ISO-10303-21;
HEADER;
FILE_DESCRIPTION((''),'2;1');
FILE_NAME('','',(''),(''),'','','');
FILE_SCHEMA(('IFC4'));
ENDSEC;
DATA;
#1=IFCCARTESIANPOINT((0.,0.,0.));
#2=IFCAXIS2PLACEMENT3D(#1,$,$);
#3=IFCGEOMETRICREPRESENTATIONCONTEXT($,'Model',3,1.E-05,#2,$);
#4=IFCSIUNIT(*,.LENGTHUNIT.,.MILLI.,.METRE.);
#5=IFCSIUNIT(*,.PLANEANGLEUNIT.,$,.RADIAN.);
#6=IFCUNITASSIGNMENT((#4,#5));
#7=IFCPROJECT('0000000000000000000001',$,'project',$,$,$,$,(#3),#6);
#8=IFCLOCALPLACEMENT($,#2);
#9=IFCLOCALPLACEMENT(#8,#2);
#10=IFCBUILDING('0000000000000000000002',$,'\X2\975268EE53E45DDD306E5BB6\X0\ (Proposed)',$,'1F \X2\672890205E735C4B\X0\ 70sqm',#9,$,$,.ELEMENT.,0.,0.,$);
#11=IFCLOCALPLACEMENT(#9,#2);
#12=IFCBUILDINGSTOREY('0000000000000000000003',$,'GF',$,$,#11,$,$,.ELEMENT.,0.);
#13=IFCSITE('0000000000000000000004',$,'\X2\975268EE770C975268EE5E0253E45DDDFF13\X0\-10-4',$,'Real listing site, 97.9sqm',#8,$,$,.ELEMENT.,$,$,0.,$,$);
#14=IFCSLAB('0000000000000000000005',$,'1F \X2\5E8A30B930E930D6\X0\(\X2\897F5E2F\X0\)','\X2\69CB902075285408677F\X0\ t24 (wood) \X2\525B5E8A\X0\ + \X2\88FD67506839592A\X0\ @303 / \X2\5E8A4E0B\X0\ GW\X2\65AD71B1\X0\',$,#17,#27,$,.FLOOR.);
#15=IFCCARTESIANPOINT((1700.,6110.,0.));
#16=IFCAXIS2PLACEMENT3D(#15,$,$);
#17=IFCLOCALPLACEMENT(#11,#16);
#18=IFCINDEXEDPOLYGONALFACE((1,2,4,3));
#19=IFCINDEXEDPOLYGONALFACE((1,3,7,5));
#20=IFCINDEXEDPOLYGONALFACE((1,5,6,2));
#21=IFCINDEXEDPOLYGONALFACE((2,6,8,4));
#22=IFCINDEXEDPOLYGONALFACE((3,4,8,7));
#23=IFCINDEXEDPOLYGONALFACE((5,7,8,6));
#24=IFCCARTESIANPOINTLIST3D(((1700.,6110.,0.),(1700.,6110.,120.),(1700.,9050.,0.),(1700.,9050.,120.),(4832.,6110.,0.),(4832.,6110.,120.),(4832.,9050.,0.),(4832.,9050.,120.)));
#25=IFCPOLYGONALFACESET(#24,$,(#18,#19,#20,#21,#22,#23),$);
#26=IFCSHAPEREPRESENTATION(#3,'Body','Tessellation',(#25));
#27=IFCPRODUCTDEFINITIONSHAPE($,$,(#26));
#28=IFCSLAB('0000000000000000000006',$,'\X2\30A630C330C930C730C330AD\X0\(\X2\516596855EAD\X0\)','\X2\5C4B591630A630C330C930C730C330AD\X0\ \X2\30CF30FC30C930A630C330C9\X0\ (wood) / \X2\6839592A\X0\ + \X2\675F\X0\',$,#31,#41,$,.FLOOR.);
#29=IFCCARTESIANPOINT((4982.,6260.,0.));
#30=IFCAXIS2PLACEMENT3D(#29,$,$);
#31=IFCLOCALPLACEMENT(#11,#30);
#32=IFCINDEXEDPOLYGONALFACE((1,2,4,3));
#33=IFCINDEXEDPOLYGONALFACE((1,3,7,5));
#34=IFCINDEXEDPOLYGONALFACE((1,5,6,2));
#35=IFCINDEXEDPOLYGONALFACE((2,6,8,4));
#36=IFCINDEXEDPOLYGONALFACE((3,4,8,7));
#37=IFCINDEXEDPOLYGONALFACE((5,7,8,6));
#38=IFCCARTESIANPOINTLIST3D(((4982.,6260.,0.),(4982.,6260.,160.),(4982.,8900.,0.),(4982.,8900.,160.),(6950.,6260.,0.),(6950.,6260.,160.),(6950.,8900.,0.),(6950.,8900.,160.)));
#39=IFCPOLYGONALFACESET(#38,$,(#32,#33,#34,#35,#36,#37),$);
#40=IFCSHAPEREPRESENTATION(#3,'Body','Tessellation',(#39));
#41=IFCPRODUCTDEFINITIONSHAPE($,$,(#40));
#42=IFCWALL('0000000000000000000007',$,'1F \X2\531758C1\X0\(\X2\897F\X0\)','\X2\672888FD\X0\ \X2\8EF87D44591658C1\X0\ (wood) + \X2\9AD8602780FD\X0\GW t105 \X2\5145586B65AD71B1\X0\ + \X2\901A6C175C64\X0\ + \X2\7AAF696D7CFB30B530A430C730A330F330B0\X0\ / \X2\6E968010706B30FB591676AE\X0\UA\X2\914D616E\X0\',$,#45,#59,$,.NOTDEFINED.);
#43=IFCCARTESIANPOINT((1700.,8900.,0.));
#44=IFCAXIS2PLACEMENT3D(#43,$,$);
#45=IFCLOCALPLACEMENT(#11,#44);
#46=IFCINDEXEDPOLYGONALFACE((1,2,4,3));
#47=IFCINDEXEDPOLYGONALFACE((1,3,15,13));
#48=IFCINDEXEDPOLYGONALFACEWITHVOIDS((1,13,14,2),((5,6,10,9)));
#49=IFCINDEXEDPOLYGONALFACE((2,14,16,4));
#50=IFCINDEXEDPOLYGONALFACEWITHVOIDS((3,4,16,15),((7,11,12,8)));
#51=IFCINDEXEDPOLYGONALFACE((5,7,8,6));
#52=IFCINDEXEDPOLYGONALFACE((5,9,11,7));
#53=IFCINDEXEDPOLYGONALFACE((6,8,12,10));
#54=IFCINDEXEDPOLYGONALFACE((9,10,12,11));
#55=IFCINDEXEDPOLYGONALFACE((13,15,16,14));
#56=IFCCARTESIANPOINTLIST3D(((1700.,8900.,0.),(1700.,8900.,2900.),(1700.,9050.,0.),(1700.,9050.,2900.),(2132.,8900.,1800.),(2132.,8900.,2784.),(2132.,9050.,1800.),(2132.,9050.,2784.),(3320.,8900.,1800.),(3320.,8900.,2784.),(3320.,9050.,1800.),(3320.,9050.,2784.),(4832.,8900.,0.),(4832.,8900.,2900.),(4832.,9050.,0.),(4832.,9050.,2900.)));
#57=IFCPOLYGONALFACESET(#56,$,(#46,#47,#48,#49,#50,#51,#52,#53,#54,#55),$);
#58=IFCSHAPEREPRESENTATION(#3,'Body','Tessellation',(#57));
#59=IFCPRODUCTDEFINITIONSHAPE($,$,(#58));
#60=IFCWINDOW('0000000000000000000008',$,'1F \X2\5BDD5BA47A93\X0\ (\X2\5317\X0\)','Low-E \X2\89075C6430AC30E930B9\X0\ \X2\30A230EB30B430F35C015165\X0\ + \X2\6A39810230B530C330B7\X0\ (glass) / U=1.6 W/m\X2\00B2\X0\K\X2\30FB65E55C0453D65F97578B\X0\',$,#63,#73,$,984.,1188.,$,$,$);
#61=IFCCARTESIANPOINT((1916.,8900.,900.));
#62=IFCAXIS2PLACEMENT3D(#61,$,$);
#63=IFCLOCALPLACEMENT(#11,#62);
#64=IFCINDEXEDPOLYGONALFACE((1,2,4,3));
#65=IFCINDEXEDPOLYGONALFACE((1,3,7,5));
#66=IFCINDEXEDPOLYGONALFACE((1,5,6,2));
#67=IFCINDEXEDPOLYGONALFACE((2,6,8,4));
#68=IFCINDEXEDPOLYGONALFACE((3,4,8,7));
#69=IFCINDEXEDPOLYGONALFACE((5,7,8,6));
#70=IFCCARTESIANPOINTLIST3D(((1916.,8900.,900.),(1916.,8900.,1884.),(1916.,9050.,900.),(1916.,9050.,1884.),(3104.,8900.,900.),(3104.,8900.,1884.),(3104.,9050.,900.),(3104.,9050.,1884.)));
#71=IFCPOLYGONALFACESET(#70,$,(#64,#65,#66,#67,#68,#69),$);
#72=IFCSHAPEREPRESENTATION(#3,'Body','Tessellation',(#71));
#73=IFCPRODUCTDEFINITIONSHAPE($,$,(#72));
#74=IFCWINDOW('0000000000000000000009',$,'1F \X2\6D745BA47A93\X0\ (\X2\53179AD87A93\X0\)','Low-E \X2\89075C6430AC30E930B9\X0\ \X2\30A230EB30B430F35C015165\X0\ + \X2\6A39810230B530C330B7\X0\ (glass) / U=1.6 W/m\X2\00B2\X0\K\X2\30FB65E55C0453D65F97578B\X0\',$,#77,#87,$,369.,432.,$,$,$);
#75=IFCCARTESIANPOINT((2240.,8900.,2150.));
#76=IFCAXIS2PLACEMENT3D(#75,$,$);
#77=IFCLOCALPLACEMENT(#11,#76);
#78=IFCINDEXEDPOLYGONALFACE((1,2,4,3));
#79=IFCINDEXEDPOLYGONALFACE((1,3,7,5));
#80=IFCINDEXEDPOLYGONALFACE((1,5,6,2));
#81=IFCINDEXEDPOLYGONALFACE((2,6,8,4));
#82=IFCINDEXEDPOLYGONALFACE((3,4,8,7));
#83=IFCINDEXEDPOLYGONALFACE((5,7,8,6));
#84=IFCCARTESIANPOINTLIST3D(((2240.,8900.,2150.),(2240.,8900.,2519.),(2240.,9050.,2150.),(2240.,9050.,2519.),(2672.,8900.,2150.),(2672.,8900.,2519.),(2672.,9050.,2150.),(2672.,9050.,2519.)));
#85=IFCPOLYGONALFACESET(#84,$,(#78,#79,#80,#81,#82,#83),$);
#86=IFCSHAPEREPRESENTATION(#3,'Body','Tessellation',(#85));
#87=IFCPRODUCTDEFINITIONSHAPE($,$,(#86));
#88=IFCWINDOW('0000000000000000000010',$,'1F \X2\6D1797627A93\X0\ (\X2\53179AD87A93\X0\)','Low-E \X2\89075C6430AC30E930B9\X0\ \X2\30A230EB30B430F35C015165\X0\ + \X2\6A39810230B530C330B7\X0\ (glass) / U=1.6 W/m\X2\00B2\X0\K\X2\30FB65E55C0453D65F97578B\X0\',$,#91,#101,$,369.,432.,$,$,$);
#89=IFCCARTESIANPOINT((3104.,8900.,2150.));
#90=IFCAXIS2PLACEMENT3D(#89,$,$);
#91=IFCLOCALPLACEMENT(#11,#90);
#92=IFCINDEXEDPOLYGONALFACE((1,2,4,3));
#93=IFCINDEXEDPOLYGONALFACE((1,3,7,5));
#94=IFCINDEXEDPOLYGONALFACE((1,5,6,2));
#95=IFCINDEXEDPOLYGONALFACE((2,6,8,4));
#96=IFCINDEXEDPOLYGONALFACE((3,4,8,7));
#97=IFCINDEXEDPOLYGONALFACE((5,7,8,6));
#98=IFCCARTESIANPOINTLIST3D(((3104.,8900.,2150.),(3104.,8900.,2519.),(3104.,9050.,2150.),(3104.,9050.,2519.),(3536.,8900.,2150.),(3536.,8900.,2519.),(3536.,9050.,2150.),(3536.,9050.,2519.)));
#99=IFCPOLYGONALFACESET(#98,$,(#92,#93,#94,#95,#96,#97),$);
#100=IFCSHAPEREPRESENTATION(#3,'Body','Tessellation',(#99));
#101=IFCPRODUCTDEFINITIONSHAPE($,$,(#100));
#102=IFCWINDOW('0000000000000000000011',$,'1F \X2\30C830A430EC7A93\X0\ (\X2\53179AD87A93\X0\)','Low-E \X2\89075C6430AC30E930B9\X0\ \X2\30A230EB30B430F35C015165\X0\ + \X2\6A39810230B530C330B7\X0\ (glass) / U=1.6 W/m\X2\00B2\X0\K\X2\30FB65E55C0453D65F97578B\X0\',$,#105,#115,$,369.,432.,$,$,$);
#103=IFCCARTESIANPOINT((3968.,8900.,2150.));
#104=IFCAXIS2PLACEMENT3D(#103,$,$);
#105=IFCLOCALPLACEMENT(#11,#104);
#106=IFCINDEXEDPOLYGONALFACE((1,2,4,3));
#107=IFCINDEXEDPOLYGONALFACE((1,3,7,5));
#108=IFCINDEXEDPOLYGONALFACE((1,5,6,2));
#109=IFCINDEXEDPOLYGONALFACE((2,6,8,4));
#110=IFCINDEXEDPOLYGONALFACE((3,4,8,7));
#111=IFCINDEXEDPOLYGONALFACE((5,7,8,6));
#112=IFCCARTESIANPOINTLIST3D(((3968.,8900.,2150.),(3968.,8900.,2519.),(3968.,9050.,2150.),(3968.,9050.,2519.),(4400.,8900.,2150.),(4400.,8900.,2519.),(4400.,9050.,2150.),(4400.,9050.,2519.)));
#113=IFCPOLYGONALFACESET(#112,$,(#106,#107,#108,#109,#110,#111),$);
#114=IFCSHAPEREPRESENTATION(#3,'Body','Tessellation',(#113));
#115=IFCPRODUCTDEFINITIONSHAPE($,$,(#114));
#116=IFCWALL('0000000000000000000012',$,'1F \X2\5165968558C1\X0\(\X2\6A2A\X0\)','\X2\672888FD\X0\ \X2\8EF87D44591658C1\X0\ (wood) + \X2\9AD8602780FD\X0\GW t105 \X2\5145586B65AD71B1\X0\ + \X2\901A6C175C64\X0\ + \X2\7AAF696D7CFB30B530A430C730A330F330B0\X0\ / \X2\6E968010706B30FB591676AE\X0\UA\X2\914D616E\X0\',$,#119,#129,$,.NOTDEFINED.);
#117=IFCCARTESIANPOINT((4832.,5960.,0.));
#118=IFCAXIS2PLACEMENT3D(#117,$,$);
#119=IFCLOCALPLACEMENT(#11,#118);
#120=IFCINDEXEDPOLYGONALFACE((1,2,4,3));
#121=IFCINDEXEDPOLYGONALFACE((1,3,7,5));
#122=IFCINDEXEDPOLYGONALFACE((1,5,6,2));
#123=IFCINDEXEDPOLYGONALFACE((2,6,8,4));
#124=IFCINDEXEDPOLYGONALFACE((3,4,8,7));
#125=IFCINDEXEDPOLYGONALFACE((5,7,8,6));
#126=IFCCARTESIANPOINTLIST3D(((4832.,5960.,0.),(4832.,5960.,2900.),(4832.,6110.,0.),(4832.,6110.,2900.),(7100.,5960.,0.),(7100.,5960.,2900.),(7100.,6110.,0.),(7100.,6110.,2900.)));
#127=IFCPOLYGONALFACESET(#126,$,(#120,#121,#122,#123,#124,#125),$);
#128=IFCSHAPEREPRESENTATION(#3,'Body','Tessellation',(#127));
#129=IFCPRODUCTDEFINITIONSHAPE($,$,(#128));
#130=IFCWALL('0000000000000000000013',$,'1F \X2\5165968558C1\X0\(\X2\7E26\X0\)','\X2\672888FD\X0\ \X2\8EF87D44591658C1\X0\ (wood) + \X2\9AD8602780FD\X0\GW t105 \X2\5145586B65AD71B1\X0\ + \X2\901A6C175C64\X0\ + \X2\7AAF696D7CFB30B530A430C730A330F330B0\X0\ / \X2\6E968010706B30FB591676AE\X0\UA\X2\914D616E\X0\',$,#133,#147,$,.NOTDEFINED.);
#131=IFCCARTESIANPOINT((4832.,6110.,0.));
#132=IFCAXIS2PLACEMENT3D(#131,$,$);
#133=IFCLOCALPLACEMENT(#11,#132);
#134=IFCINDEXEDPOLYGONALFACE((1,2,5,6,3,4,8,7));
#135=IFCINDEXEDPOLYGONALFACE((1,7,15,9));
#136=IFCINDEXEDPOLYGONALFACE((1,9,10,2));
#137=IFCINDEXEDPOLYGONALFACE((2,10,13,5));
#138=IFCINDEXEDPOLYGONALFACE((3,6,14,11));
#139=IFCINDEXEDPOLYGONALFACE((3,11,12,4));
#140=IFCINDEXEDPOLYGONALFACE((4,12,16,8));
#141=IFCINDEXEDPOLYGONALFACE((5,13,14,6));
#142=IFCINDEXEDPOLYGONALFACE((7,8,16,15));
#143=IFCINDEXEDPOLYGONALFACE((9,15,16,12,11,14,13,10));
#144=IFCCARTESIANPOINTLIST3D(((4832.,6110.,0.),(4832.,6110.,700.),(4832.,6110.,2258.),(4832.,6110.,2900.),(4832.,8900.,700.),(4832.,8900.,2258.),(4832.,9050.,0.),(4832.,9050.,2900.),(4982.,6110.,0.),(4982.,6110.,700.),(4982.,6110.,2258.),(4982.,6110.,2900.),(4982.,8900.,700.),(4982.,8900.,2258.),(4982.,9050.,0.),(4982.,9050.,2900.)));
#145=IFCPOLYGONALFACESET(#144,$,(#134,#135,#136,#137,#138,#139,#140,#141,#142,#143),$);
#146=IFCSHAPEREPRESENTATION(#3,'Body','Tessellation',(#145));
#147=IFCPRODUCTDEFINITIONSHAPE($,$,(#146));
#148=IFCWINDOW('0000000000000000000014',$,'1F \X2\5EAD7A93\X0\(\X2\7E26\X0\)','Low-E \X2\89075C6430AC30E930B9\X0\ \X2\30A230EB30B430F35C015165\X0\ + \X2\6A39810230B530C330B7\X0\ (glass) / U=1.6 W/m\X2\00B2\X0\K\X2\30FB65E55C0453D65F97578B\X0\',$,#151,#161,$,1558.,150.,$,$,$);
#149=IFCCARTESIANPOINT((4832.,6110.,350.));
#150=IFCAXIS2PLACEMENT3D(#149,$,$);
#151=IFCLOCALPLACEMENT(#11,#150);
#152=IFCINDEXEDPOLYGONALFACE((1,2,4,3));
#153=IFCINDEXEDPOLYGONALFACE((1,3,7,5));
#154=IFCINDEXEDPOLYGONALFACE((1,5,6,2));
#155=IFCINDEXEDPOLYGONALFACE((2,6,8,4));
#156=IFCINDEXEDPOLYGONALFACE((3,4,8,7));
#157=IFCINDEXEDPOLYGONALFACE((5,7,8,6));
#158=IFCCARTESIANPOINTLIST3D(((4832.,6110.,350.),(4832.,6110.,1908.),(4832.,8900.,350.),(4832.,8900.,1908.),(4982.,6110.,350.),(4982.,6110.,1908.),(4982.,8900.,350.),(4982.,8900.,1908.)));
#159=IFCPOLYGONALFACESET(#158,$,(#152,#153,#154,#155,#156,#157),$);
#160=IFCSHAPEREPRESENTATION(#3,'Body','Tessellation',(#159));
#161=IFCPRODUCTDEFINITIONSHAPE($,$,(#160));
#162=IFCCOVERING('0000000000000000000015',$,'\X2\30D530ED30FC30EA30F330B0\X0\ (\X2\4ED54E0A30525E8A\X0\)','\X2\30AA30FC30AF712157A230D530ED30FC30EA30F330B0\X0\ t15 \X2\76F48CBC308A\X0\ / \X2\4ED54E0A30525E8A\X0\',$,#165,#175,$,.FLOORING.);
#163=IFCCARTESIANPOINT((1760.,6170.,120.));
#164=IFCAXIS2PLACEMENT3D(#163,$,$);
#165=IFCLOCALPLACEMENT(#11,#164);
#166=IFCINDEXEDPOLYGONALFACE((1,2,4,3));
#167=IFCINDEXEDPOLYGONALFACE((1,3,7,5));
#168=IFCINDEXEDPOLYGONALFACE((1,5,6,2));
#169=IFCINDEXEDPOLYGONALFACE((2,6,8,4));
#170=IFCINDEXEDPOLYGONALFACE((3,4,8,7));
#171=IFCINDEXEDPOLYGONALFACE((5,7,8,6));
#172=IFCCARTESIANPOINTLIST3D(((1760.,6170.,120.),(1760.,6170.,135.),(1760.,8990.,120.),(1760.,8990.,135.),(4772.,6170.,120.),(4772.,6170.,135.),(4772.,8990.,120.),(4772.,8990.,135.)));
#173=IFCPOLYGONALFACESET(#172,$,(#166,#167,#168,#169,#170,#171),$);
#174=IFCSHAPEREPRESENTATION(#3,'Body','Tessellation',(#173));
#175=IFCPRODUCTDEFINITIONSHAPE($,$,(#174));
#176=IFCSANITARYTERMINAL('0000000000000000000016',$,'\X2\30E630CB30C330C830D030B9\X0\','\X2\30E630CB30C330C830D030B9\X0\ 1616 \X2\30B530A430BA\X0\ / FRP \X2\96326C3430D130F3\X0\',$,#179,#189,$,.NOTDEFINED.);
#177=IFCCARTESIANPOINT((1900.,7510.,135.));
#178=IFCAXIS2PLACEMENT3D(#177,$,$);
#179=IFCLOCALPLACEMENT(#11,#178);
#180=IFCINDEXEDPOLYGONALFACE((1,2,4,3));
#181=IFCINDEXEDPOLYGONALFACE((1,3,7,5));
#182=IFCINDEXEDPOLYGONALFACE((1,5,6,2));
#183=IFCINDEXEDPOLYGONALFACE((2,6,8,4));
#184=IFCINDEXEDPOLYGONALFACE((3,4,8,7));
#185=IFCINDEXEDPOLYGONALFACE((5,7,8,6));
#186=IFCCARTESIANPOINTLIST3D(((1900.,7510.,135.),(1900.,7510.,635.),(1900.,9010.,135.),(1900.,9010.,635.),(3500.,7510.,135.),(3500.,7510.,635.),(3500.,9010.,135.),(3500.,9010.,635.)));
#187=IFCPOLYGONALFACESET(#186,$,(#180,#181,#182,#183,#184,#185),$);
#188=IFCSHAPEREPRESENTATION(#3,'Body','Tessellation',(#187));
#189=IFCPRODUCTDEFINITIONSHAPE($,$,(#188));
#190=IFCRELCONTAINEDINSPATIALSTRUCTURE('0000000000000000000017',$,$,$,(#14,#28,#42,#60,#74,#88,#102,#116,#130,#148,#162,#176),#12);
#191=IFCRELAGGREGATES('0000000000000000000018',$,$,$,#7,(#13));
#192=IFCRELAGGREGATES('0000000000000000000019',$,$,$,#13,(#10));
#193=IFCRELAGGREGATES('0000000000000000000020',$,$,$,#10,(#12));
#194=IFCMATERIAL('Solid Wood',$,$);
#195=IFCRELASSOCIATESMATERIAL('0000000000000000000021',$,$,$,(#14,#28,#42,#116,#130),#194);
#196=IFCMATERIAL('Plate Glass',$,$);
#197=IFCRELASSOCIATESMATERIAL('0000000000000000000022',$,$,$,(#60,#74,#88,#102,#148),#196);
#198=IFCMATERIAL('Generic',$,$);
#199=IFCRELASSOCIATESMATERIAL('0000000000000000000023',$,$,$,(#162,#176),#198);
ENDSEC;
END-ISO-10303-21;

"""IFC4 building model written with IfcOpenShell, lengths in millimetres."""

from ifc_helpers import new_model, si_unit, frame, frame_2d, origin, place, context, project, spatial, rectangle, extrude, material, element, fill, save


model = new_model("IFC4")

# Units and contexts
model_context = context("Model", 3, precision=1e-05, world=origin())
ifc_project = project(units=[si_unit("LENGTHUNIT", "METRE", prefix="MILLI"), si_unit("PLANEANGLEUNIT", "RADIAN")], contexts=[model_context])

# Site, building, storey
site_placement = place(None, origin())
site = spatial("IfcSite", under=ifc_project, at=site_placement, Name="青森県青森市古川３-10-4", ObjectType="Real listing site, 97.9sqm", CompositionType="ELEMENT", RefElevation=0.0)
building_placement = place(site_placement, origin())
building = spatial("IfcBuilding", under=site, at=building_placement, Name="青森古川の家 (Proposed)", ObjectType="1F 木造平屋 70sqm", CompositionType="ELEMENT", ElevationOfRefHeight=0.0, ElevationOfTerrain=0.0)
storey_placement = place(building_placement, origin())
storey = spatial("IfcBuildingStorey", under=building, at=storey_placement, Name="GF", CompositionType="ELEMENT", Elevation=0.0)

# Slabs
ifc_material_1 = material(Name="Solid Wood")
slab_1_placement = place(storey_placement, frame((1700.0, 6110.0, 0.0)))
element("IfcSlab", 1, at=slab_1_placement, inside=storey, material=ifc_material_1, Name="1F 床スラブ(西帯)", Description="構造用合板 t24 (wood) 剛床 + 製材根太 @303 / 床下 GW断熱", PredefinedType="FLOOR", context=model_context, shape_type="SweptSolid", body=[
    extrude(rectangle(XDim=3132.0, YDim=2940.0, at=frame_2d((1566.0, 1470.0))), frame((1700.0, 6110.0, 0.0)), (0.0, 0.0, 1.0), 120.0),
])
slab_2_placement = place(storey_placement, frame((4982.0, 6260.0, 0.0)))
element("IfcSlab", 2, at=slab_2_placement, inside=storey, material=ifc_material_1, Name="ウッドデッキ(入隅庭)", Description="屋外ウッドデッキ ハードウッド (wood) / 根太 + 束", PredefinedType="FLOOR", context=model_context, shape_type="SweptSolid", body=[
    extrude(rectangle(XDim=1968.0, YDim=2640.0, at=frame_2d((984.0, 1320.0))), frame((4982.0, 6260.0, 0.0)), (0.0, 0.0, 1.0), 160.0),
])

# Wall, openings, windows
wall_1_placement = place(storey_placement, frame((1700.0, 8900.0, 0.0)))
wall_1 = element("IfcWall", 3, at=wall_1_placement, inside=storey, material=ifc_material_1, Name="1F 北壁(西)", Description="木製 軸組外壁 (wood) + 高性能GW t105 充填断熱 + 通気層 + 窯業系サイディング / 準耐火・外皮UA配慮", PredefinedType="NOTDEFINED", context=model_context, shape_type="SweptSolid", body=[
    extrude(rectangle(XDim=3132.0, YDim=150.0, at=frame_2d((1566.0, 75.0))), frame((1700.0, 8900.0, 0.0)), (0.0, 0.0, 1.0), 2900.0),
])
opening_1_placement = place(storey_placement, frame((1916.0, 8900.0, 900.0)))
opening_1 = element("IfcOpeningElement", 4, at=opening_1_placement, cuts=wall_1, PredefinedType="NOTDEFINED", context=model_context, shape_type="SweptSolid", body=[
    extrude(rectangle(XDim=1188.0, YDim=150.0, at=frame_2d((594.0, 75.0))), frame((1916.0, 8900.0, 900.0)), (0.0, 0.0, 1.0), 984.0),
])
opening_2_placement = place(storey_placement, frame((2240.0, 8900.0, 2150.0)))
opening_2 = element("IfcOpeningElement", 5, at=opening_2_placement, cuts=wall_1, PredefinedType="NOTDEFINED", context=model_context, shape_type="SweptSolid", body=[
    extrude(rectangle(XDim=432.0, YDim=150.0, at=frame_2d((216.0, 75.0))), frame((2240.0, 8900.0, 2150.0)), (0.0, 0.0, 1.0), 369.0),
])
opening_3_placement = place(storey_placement, frame((3104.0, 8900.0, 2150.0)))
opening_3 = element("IfcOpeningElement", 6, at=opening_3_placement, cuts=wall_1, PredefinedType="NOTDEFINED", context=model_context, shape_type="SweptSolid", body=[
    extrude(rectangle(XDim=432.0, YDim=150.0, at=frame_2d((216.0, 75.0))), frame((3104.0, 8900.0, 2150.0)), (0.0, 0.0, 1.0), 369.0),
])
opening_4_placement = place(storey_placement, frame((3968.0, 8900.0, 2150.0)))
opening_4 = element("IfcOpeningElement", 7, at=opening_4_placement, cuts=wall_1, PredefinedType="NOTDEFINED", context=model_context, shape_type="SweptSolid", body=[
    extrude(rectangle(XDim=432.0, YDim=150.0, at=frame_2d((216.0, 75.0))), frame((3968.0, 8900.0, 2150.0)), (0.0, 0.0, 1.0), 369.0),
])
ifc_material_2 = material(Name="Plate Glass")
window_1_placement = place(storey_placement, frame((1916.0, 8900.0, 900.0)))
window_1 = element("IfcWindow", 8, at=window_1_placement, inside=storey, material=ifc_material_2, Name="1F 寝室窓 (北)", Description="Low-E 複層ガラス アルゴン封入 + 樹脂サッシ (glass) / U=1.6 W/m²K・日射取得型", OverallHeight=984.0, OverallWidth=1188.0, context=model_context, shape_type="SweptSolid", body=[
    extrude(rectangle(XDim=1188.0, YDim=150.0, at=frame_2d((594.0, 75.0))), frame((1916.0, 8900.0, 900.0)), (0.0, 0.0, 1.0), 984.0),
])
fill(opening_1, window_1)
window_2_placement = place(storey_placement, frame((2240.0, 8900.0, 2150.0)))
window_2 = element("IfcWindow", 9, at=window_2_placement, inside=storey, material=ifc_material_2, Name="1F 浴室窓 (北高窓)", Description="Low-E 複層ガラス アルゴン封入 + 樹脂サッシ (glass) / U=1.6 W/m²K・日射取得型", OverallHeight=369.0, OverallWidth=432.0, context=model_context, shape_type="SweptSolid", body=[
    extrude(rectangle(XDim=432.0, YDim=150.0, at=frame_2d((216.0, 75.0))), frame((2240.0, 8900.0, 2150.0)), (0.0, 0.0, 1.0), 369.0),
])
fill(opening_2, window_2)
window_3_placement = place(storey_placement, frame((3104.0, 8900.0, 2150.0)))
window_3 = element("IfcWindow", 10, at=window_3_placement, inside=storey, material=ifc_material_2, Name="1F 洗面窓 (北高窓)", Description="Low-E 複層ガラス アルゴン封入 + 樹脂サッシ (glass) / U=1.6 W/m²K・日射取得型", OverallHeight=369.0, OverallWidth=432.0, context=model_context, shape_type="SweptSolid", body=[
    extrude(rectangle(XDim=432.0, YDim=150.0, at=frame_2d((216.0, 75.0))), frame((3104.0, 8900.0, 2150.0)), (0.0, 0.0, 1.0), 369.0),
])
fill(opening_3, window_3)
window_4_placement = place(storey_placement, frame((3968.0, 8900.0, 2150.0)))
window_4 = element("IfcWindow", 11, at=window_4_placement, inside=storey, material=ifc_material_2, Name="1F トイレ窓 (北高窓)", Description="Low-E 複層ガラス アルゴン封入 + 樹脂サッシ (glass) / U=1.6 W/m²K・日射取得型", OverallHeight=369.0, OverallWidth=432.0, context=model_context, shape_type="SweptSolid", body=[
    extrude(rectangle(XDim=432.0, YDim=150.0, at=frame_2d((216.0, 75.0))), frame((3968.0, 8900.0, 2150.0)), (0.0, 0.0, 1.0), 369.0),
])
fill(opening_4, window_4)

# Wall
wall_2_placement = place(storey_placement, frame((4832.0, 5960.0, 0.0)))
element("IfcWall", 12, at=wall_2_placement, inside=storey, material=ifc_material_1, Name="1F 入隅壁(横)", Description="木製 軸組外壁 (wood) + 高性能GW t105 充填断熱 + 通気層 + 窯業系サイディング / 準耐火・外皮UA配慮", PredefinedType="NOTDEFINED", context=model_context, shape_type="SweptSolid", body=[
    extrude(rectangle(XDim=2268.0, YDim=150.0, at=frame_2d((1134.0, 75.0))), frame((4832.0, 5960.0, 0.0)), (0.0, 0.0, 1.0), 2900.0),
])

# Wall, opening, window
wall_3_placement = place(storey_placement, frame((4832.0, 6110.0, 0.0)))
wall_3 = element("IfcWall", 13, at=wall_3_placement, inside=storey, material=ifc_material_1, Name="1F 入隅壁(縦)", Description="木製 軸組外壁 (wood) + 高性能GW t105 充填断熱 + 通気層 + 窯業系サイディング / 準耐火・外皮UA配慮", PredefinedType="NOTDEFINED", context=model_context, shape_type="SweptSolid", body=[
    extrude(rectangle(XDim=150.0, YDim=2940.0, at=frame_2d((75.0, 1470.0))), frame((4832.0, 6110.0, 0.0)), (0.0, 0.0, 1.0), 2900.0),
])
opening_5_placement = place(storey_placement, frame((4832.0, 6110.0, 350.0)))
opening_5 = element("IfcOpeningElement", 14, at=opening_5_placement, cuts=wall_3, PredefinedType="NOTDEFINED", context=model_context, shape_type="SweptSolid", body=[
    extrude(rectangle(XDim=150.0, YDim=2790.0, at=frame_2d((75.0, 1395.0))), frame((4832.0, 6110.0, 350.0)), (0.0, 0.0, 1.0), 1558.0),
])
window_5_placement = place(storey_placement, frame((4832.0, 6110.0, 350.0)))
window_5 = element("IfcWindow", 15, at=window_5_placement, inside=storey, material=ifc_material_2, Name="1F 庭窓(縦)", Description="Low-E 複層ガラス アルゴン封入 + 樹脂サッシ (glass) / U=1.6 W/m²K・日射取得型", OverallHeight=1558.0, OverallWidth=150.0, context=model_context, shape_type="SweptSolid", body=[
    extrude(rectangle(XDim=150.0, YDim=2790.0, at=frame_2d((75.0, 1395.0))), frame((4832.0, 6110.0, 350.0)), (0.0, 0.0, 1.0), 1558.0),
])
fill(opening_5, window_5)

# Covering
ifc_material_3 = material(Name="Generic")
covering_placement = place(storey_placement, frame((1760.0, 6170.0, 120.0)))
element("IfcCovering", 16, at=covering_placement, inside=storey, material=ifc_material_3, Name="フローリング (仕上げ床)", Description="オーク無垢フローリング t15 直貼り / 仕上げ床", PredefinedType="FLOORING", context=model_context, shape_type="SweptSolid", body=[
    extrude(rectangle(XDim=3012.0, YDim=2820.0, at=frame_2d((1506.0, 1410.0))), frame((1760.0, 6170.0, 120.0)), (0.0, 0.0, 1.0), 15.0),
])

# Sanitary terminal
sanitary_terminal_1_placement = place(storey_placement, frame((1900.0, 7510.0, 135.0)))
element("IfcSanitaryTerminal", 17, at=sanitary_terminal_1_placement, inside=storey, material=ifc_material_3, Name="ユニットバス", Description="ユニットバス 1616 サイズ / FRP 防水パン", PredefinedType="NOTDEFINED", context=model_context, shape_type="SweptSolid", body=[
    extrude(rectangle(XDim=1600.0, YDim=1500.0, at=frame_2d((800.0, 750.0))), frame((1900.0, 7510.0, 135.0)), (0.0, 0.0, 1.0), 500.0),
])

save(model, "model.ifc")
